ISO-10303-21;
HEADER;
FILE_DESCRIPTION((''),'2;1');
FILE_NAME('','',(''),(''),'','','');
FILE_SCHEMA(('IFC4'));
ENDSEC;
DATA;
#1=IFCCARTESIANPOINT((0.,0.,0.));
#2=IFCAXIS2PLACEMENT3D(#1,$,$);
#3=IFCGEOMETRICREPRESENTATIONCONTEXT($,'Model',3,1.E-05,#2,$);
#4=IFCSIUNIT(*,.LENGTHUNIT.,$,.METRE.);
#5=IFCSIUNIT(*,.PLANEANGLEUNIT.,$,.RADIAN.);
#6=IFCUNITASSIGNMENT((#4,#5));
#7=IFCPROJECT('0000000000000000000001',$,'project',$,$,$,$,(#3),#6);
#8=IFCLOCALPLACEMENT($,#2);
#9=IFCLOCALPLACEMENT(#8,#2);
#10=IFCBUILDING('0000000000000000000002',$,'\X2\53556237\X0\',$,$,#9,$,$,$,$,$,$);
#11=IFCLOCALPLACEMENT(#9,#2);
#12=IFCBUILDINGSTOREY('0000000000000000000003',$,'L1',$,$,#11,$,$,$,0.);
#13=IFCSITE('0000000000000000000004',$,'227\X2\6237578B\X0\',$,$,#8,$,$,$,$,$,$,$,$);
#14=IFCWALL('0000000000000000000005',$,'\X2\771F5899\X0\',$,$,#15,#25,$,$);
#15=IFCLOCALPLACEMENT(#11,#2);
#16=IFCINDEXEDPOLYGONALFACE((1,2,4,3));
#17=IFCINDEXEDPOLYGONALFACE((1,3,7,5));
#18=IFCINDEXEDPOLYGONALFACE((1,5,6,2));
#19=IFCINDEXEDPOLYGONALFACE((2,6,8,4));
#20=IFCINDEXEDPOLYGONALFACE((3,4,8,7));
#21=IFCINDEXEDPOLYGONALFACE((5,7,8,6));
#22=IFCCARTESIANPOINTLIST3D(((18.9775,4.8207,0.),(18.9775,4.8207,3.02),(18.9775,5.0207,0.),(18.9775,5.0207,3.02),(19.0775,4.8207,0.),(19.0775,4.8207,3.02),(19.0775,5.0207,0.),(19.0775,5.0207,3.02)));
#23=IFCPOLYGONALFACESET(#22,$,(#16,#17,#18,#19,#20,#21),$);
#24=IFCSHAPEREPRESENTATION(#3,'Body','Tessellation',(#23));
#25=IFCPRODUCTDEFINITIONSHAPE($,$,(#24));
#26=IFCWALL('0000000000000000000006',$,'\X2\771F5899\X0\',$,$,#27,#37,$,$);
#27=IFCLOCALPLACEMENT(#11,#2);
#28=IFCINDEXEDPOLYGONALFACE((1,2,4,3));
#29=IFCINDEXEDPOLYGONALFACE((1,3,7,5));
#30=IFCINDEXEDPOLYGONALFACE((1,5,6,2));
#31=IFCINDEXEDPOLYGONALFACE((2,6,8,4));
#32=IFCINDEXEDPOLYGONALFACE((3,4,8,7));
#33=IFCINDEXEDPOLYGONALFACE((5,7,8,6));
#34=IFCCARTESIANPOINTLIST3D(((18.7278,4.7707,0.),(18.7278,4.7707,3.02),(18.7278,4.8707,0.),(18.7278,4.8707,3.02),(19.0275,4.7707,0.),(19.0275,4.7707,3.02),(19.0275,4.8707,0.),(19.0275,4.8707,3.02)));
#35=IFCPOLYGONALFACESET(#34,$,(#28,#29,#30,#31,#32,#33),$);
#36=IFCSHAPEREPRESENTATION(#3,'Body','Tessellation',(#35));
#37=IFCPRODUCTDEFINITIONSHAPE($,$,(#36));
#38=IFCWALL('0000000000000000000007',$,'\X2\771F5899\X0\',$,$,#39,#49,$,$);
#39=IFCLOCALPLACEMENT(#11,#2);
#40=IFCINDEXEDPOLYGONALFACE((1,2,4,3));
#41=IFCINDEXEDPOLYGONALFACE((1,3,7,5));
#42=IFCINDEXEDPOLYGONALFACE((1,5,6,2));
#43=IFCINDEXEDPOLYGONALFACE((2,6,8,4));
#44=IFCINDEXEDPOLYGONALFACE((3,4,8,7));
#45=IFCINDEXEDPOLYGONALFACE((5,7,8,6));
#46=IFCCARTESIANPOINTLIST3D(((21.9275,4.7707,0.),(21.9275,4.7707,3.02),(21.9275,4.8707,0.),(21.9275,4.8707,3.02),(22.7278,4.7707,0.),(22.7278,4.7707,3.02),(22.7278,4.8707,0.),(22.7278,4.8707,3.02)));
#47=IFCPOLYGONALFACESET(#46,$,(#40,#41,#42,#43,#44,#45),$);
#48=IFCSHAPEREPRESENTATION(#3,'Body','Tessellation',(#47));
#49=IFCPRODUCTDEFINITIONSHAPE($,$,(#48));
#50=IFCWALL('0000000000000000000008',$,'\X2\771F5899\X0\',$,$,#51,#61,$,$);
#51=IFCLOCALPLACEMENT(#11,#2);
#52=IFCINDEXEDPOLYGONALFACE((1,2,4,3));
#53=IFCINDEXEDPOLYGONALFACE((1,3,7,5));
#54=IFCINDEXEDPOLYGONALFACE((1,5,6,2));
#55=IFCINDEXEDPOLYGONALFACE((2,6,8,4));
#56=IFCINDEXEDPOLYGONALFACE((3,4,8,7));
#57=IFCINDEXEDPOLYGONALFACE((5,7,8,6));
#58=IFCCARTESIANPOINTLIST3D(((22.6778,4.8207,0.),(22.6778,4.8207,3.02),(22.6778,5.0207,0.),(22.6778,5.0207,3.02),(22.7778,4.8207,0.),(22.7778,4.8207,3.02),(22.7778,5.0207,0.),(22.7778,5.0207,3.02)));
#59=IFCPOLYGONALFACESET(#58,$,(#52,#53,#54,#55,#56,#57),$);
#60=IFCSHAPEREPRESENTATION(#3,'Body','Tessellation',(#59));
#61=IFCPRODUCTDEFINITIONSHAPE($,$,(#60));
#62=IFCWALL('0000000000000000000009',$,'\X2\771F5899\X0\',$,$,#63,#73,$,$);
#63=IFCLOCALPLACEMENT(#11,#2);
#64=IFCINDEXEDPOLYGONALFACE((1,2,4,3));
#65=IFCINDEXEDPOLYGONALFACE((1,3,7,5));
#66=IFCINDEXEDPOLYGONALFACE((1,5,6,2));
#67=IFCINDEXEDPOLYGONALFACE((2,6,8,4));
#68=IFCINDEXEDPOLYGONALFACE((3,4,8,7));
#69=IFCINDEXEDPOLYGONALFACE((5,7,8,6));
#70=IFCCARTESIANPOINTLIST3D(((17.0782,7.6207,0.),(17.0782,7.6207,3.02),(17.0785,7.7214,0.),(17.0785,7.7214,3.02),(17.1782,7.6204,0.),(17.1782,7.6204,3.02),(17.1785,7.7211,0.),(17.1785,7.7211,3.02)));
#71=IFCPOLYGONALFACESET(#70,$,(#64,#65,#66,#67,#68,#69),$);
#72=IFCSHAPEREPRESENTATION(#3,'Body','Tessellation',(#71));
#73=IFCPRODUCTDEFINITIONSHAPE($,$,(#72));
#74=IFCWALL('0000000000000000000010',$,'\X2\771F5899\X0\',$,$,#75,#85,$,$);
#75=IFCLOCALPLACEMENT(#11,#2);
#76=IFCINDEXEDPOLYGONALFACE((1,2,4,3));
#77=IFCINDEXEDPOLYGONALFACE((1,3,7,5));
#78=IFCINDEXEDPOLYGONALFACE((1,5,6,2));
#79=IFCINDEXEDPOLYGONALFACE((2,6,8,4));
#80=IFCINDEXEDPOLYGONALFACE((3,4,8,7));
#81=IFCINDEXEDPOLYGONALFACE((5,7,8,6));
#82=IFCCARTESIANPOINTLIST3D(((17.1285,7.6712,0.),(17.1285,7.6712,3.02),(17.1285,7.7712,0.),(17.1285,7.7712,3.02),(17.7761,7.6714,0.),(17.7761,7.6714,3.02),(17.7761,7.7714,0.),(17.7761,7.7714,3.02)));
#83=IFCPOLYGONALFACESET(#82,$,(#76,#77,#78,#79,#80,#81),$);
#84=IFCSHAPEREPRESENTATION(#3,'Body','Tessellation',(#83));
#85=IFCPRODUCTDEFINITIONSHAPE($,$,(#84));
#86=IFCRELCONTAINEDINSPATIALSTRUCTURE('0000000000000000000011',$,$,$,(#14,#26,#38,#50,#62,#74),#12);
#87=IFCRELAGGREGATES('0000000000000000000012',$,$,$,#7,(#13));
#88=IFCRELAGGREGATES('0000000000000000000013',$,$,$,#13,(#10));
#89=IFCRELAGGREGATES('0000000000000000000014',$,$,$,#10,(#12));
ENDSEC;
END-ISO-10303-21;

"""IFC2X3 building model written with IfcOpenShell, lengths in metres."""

from ifc_helpers import new_model, si_unit, origin, place, context, project, spatial, polyline, outline, extrude, element, save


model = new_model("IFC2X3")

# Units and contexts
model_context = context("Model", 3, precision=1e-05, world=origin())
ifc_project = project(units=[si_unit("LENGTHUNIT", "METRE"), si_unit("PLANEANGLEUNIT", "RADIAN")], contexts=[model_context])

# Site, building, storey
site_placement = place(None, origin())
site = spatial("IfcSite", under=ifc_project, at=site_placement, Name="227户型")
building_placement = place(site_placement, origin())
building = spatial("IfcBuilding", under=site, at=building_placement, Name="单户")
storey_placement = place(building_placement, origin())
storey = spatial("IfcBuildingStorey", under=building, at=storey_placement, Name="L1", Elevation=0.0)

# Walls
wall_1_placement = place(storey_placement, origin())
element("IfcWall", 1, at=wall_1_placement, inside=storey, Name="真墙", context=model_context, shape_type="SweptSolid", body=[
    extrude(outline(polyline([(19.0775, 5.0207), (19.0775, 4.8207), (18.9775, 4.8207), (18.9775, 5.0207), (19.0775, 5.0207)])), origin(), (0.0, 0.0, 1.0), 3.02),
])
wall_2_placement = place(storey_placement, origin())
element("IfcWall", 2, at=wall_2_placement, inside=storey, Name="真墙", context=model_context, shape_type="SweptSolid", body=[
    extrude(outline(polyline([(19.0275, 4.7707), (18.7278, 4.7707), (18.7278, 4.8707), (19.0275, 4.8707), (19.0275, 4.7707)])), origin(), (0.0, 0.0, 1.0), 3.02),
])
wall_3_placement = place(storey_placement, origin())
element("IfcWall", 3, at=wall_3_placement, inside=storey, Name="真墙", context=model_context, shape_type="SweptSolid", body=[
    extrude(outline(polyline([(21.9275, 4.8707), (22.7278, 4.8707), (22.7278, 4.7707), (21.9275, 4.7707), (21.9275, 4.8707)])), origin(), (0.0, 0.0, 1.0), 3.02),
])
wall_4_placement = place(storey_placement, origin())
element("IfcWall", 4, at=wall_4_placement, inside=storey, Name="真墙", context=model_context, shape_type="SweptSolid", body=[
    extrude(outline(polyline([(22.6778, 4.8207), (22.6778, 5.0207), (22.7778, 5.0207), (22.7778, 4.8207), (22.6778, 4.8207)])), origin(), (0.0, 0.0, 1.0), 3.02),
])

# Walls
wall_5_placement = place(storey_placement, origin())
element("IfcWall", 5, at=wall_5_placement, inside=storey, Name="真墙", context=model_context, shape_type="SweptSolid", body=[
    extrude(outline(polyline([(17.0782, 7.6207), (17.0785, 7.7214), (17.1785, 7.7211), (17.1782, 7.6204), (17.0782, 7.6207)])), origin(), (0.0, 0.0, 1.0), 3.02),
])
wall_6_placement = place(storey_placement, origin())
element("IfcWall", 6, at=wall_6_placement, inside=storey, Name="真墙", context=model_context, shape_type="SweptSolid", body=[
    extrude(outline(polyline([(17.1285, 7.7712), (17.7761, 7.7714), (17.7761, 7.6714), (17.1285, 7.6712), (17.1285, 7.7712)])), origin(), (0.0, 0.0, 1.0), 3.02),
])

save(model, "model.ifc")
